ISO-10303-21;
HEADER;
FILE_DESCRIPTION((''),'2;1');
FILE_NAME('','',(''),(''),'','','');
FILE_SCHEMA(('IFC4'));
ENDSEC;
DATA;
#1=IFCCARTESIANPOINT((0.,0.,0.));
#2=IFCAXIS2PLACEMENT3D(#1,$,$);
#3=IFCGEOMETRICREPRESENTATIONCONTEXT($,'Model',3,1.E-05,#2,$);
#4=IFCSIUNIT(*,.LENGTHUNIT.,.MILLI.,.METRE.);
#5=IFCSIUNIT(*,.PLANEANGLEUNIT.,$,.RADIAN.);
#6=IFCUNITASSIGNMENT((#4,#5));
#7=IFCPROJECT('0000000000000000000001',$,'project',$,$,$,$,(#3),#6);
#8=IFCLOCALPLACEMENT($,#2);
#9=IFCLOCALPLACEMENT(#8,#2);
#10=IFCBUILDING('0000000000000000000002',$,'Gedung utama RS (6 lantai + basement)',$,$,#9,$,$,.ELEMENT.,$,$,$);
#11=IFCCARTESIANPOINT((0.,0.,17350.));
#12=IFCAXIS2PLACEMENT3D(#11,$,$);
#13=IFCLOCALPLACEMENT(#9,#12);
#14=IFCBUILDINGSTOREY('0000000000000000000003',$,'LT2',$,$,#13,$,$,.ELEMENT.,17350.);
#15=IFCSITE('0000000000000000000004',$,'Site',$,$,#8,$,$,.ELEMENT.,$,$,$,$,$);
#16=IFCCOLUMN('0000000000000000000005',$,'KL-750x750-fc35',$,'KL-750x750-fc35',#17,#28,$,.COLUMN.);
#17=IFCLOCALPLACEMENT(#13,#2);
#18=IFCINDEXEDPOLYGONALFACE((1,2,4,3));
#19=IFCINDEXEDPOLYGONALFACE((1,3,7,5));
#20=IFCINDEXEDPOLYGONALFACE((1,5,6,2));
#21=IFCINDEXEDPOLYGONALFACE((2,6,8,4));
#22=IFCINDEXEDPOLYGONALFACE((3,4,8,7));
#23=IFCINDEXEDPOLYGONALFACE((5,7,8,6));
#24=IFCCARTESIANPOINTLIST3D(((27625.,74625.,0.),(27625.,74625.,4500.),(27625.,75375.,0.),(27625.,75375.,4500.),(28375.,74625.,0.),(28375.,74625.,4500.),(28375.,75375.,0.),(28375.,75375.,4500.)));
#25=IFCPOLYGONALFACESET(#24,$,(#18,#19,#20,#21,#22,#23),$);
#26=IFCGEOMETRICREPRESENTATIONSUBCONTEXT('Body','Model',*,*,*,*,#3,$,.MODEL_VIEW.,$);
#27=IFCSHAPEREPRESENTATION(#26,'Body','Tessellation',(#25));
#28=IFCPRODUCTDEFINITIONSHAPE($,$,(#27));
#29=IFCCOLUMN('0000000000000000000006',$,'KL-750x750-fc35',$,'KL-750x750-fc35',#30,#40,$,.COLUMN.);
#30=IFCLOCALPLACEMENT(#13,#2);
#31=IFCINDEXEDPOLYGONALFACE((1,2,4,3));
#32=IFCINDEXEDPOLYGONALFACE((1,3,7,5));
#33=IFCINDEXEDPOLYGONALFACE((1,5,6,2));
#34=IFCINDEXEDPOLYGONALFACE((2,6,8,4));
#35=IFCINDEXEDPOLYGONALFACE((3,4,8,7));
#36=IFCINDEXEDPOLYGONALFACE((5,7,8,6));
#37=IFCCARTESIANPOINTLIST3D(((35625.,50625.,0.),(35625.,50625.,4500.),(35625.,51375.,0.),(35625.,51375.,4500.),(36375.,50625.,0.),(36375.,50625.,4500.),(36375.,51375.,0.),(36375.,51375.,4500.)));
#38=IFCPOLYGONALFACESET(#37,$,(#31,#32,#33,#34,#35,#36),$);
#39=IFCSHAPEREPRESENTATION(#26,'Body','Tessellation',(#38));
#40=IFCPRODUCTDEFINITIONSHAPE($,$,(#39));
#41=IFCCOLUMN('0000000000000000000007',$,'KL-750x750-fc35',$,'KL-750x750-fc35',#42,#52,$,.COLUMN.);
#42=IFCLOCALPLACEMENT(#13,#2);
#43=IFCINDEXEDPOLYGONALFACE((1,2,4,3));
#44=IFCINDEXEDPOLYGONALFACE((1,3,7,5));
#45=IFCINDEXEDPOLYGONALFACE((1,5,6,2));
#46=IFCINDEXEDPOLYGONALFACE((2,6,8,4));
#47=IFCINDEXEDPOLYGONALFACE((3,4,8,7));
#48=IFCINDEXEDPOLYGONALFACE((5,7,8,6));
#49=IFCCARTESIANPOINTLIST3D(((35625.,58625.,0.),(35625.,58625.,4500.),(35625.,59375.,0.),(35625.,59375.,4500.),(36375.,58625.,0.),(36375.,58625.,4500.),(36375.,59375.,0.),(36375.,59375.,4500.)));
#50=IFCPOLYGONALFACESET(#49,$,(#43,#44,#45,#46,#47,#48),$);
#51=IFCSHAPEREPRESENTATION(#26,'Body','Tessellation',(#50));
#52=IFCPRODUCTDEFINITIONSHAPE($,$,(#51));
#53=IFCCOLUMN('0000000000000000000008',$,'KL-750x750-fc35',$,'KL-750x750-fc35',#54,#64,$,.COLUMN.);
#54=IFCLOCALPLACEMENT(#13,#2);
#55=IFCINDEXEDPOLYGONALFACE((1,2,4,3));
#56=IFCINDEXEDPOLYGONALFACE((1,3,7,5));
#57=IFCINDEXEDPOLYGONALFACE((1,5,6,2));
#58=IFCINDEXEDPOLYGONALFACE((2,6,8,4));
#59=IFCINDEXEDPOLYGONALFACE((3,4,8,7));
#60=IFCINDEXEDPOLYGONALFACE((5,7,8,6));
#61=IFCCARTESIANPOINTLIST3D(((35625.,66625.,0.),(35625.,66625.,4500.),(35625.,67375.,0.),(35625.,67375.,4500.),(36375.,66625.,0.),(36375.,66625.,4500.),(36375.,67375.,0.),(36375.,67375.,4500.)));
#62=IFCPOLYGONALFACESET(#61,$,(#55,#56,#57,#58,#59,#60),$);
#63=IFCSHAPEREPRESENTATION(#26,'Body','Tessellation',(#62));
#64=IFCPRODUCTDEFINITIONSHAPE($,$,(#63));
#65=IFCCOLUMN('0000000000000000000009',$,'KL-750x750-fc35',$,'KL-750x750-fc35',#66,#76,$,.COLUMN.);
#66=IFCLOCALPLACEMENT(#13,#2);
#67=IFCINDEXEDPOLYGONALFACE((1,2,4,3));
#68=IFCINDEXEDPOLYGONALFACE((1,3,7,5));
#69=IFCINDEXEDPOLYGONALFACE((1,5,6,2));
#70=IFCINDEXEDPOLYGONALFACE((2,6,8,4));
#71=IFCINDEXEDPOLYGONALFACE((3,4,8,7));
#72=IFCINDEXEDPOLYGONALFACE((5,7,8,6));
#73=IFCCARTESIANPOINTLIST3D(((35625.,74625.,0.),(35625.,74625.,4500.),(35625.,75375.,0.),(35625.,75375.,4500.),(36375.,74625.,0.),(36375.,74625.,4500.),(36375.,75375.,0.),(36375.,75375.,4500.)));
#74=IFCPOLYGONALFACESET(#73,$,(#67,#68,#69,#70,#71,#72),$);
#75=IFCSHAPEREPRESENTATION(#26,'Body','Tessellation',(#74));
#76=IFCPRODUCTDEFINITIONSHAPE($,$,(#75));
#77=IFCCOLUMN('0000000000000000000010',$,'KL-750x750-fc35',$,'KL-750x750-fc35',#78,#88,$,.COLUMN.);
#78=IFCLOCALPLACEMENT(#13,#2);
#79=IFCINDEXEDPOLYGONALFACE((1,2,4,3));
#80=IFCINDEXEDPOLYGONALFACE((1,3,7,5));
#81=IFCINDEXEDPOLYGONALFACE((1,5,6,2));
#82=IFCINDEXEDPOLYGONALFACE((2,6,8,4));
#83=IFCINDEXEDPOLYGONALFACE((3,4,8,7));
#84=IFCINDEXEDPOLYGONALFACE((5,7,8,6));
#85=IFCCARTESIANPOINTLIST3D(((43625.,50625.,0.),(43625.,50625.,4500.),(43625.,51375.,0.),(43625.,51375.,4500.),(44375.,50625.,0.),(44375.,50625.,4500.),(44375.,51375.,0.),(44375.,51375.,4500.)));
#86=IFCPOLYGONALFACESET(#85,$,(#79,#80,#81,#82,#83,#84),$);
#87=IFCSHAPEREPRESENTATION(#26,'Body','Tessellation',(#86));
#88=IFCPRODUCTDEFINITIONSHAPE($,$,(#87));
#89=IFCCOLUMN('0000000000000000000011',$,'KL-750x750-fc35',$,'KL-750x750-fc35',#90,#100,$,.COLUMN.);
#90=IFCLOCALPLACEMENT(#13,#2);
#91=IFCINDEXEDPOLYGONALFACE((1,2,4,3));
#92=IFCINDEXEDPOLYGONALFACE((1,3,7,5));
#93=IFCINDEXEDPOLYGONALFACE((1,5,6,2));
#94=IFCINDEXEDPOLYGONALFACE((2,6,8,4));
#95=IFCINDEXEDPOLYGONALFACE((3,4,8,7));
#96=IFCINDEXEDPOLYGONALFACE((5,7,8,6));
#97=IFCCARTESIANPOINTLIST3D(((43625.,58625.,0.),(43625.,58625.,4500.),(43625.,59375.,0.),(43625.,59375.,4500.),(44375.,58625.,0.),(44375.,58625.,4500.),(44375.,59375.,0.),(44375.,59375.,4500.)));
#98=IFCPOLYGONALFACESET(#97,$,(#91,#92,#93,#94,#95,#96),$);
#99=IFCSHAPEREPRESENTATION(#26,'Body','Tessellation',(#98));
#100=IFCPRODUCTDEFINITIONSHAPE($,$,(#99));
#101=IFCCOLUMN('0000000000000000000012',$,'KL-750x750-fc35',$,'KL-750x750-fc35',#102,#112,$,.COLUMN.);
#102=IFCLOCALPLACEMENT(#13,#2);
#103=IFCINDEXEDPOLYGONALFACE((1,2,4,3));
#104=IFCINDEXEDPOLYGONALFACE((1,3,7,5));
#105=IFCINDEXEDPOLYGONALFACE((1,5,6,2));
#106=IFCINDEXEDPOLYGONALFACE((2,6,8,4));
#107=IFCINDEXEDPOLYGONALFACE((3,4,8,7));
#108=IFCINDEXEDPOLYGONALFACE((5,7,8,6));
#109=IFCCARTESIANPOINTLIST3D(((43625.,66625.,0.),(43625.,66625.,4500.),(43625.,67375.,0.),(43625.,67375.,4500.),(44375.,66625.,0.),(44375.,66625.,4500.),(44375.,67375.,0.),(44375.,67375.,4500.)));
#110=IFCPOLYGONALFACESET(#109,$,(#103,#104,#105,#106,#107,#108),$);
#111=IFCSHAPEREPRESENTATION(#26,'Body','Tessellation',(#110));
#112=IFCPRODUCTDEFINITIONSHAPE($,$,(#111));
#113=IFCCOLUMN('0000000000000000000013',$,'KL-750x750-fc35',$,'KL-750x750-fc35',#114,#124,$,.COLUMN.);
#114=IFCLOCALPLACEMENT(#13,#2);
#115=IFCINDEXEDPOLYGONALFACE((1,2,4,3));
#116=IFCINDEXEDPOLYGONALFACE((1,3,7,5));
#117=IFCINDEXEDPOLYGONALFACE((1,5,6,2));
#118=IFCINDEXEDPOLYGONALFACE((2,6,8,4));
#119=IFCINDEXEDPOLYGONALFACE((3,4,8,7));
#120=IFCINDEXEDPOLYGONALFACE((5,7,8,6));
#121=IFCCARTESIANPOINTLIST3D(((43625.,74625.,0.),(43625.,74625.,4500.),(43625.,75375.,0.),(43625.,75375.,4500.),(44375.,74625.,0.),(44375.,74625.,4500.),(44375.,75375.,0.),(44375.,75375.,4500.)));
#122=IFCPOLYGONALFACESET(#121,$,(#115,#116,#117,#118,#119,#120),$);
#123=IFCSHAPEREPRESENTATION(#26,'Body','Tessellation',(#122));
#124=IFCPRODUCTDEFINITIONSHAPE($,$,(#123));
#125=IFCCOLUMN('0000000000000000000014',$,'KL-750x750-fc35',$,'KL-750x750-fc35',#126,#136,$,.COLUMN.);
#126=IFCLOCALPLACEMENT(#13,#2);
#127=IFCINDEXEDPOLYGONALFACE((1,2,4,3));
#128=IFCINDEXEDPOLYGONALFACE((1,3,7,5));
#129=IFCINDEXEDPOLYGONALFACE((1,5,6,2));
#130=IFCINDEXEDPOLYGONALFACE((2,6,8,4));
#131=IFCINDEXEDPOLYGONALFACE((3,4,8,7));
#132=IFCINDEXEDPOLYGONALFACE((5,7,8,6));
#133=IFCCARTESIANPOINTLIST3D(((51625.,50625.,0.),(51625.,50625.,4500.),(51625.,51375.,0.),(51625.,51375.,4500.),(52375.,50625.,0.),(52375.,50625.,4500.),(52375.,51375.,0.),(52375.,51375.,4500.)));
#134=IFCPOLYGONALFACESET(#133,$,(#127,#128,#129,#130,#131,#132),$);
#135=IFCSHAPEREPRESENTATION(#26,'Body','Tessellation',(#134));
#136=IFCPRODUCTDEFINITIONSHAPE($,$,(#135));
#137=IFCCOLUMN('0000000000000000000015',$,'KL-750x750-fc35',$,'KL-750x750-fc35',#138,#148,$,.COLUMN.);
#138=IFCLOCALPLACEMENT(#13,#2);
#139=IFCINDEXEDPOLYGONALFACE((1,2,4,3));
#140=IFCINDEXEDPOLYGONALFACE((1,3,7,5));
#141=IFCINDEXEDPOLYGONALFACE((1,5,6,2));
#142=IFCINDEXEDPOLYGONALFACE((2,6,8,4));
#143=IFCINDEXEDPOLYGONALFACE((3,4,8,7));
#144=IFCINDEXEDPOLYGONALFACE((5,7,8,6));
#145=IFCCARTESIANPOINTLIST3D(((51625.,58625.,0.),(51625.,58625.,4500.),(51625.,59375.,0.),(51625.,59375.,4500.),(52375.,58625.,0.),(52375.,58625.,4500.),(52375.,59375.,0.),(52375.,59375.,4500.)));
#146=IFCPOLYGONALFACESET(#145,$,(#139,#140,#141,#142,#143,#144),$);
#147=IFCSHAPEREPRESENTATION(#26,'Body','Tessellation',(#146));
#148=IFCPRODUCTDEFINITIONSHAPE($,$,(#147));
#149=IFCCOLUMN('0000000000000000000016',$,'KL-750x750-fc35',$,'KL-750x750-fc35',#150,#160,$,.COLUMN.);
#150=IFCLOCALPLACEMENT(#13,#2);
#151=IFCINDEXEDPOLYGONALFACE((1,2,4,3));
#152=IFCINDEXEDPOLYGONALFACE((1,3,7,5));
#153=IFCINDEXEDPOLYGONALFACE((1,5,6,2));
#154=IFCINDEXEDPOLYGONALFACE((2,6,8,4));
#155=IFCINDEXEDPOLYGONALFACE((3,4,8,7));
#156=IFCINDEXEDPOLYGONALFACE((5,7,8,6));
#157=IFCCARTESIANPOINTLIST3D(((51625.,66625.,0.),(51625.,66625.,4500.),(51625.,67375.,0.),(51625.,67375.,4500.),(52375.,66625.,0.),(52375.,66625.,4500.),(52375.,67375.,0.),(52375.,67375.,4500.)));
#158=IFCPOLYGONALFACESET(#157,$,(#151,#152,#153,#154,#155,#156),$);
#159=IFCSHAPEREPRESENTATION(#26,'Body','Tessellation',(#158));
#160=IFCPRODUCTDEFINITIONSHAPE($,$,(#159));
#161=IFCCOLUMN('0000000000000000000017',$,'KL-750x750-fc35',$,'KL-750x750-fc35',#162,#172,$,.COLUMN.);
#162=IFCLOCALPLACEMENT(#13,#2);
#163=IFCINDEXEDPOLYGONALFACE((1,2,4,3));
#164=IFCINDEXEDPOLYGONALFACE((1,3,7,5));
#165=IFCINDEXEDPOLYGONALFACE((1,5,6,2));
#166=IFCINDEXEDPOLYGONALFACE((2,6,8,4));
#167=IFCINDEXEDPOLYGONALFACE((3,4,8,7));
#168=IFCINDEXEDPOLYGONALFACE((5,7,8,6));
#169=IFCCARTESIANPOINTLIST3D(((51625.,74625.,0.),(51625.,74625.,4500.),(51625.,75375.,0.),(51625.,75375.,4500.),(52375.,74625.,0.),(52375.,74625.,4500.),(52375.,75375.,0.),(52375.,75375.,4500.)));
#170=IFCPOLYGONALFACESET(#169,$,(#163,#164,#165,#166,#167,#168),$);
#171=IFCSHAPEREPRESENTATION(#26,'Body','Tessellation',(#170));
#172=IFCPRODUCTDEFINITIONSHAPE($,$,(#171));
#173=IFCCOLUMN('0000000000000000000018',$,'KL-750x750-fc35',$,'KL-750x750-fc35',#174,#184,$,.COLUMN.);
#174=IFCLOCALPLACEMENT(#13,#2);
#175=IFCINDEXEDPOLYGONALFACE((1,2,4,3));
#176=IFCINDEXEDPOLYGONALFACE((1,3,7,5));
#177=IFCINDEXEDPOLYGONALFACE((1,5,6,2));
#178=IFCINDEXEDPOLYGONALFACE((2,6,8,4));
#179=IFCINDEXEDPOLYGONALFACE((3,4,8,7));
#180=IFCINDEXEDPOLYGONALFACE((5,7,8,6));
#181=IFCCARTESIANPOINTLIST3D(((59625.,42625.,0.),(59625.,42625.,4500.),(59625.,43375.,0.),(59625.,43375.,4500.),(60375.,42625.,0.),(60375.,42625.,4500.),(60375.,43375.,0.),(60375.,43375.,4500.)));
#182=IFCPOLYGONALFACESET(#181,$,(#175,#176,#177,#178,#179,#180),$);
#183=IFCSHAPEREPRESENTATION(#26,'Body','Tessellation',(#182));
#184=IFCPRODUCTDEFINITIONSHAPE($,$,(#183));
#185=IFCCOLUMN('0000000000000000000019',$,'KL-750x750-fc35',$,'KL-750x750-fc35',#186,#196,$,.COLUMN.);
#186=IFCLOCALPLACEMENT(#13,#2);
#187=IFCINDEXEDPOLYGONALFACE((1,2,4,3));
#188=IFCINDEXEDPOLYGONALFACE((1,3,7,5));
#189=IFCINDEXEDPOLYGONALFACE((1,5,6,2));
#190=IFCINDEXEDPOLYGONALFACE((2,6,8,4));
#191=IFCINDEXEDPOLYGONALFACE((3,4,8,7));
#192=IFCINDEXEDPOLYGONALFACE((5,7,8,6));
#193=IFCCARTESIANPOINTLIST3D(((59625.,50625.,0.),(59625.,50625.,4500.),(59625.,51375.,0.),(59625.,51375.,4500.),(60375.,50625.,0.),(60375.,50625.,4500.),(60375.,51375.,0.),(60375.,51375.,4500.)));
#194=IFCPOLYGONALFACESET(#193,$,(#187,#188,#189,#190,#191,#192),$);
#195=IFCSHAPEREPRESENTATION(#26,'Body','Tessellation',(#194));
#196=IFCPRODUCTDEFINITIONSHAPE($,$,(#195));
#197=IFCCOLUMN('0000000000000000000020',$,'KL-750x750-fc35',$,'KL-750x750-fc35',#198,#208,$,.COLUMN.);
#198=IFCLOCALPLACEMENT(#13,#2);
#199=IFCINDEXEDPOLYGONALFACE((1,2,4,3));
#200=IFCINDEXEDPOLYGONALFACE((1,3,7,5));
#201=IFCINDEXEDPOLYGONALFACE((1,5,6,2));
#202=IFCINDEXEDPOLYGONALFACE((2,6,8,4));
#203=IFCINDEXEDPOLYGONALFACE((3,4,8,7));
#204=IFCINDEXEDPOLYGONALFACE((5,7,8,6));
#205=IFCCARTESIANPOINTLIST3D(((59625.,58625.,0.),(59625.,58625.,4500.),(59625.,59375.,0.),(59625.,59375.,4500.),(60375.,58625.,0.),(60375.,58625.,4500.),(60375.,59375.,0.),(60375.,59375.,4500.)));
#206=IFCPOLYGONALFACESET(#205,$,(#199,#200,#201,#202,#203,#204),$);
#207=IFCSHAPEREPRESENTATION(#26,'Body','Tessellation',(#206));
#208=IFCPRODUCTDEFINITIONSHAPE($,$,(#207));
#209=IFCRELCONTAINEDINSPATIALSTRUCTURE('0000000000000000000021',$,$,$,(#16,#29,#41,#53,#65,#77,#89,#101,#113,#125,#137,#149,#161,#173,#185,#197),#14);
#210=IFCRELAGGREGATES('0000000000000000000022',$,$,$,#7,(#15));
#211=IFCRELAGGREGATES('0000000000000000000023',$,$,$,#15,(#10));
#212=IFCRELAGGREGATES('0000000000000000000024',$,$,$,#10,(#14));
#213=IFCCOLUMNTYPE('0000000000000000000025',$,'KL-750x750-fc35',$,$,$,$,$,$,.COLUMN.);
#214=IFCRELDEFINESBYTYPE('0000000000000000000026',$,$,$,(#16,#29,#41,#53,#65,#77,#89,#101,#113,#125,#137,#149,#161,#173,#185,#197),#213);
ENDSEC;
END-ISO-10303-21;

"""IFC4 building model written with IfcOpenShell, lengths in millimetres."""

from ifc_helpers import new_model, si_unit, frame, origin, origin_2d, place, context, subcontext, project, spatial, rectangle, extrude, material_profile, profile_set, profile_usage, type_object, element, save


model = new_model("IFC4")

# Units and contexts
model_context = context("Model", 3, precision=1e-05, world=origin())
body_context = subcontext(model_context, "Body", "Model", "MODEL_VIEW")
ifc_project = project(units=[si_unit("LENGTHUNIT", "METRE", prefix="MILLI"), si_unit("PLANEANGLEUNIT", "RADIAN")], contexts=[model_context])

# Site, building, storey
site_placement = place(None, origin())
site = spatial("IfcSite", under=ifc_project, at=site_placement, Name="Site", CompositionType="ELEMENT")
building_placement = place(site_placement, origin())
building = spatial("IfcBuilding", under=site, at=building_placement, Name="Gedung utama RS (6 lantai + basement)", CompositionType="ELEMENT")
storey_placement = place(building_placement, frame((0.0, 0.0, 17350.0)))
storey = spatial("IfcBuildingStorey", under=building, at=storey_placement, Name="LT2", CompositionType="ELEMENT", Elevation=17350.0)

# Columns
ifc_material_profile = material_profile(None, rectangle(XDim=750.0, YDim=750.0, at=origin_2d()), Name="KL-750x750-fc35")
ifc_profile_set = profile_set([ifc_material_profile], Name="KL-750x750-fc35")
ifc_profile_usage = profile_usage(ifc_profile_set, cardinal=5)
column_type = type_object("IfcColumnType", Name="KL-750x750-fc35", PredefinedType="COLUMN", material=ifc_profile_set)
for number, where, z_axis, x_axis, name in (
    (1, (28000.0, 75000.0, 0.0), (0.0, 0.0, 1.0), (1.0, 0.0, 0.0), "KL-750x750-fc35"),
    (2, (36000.0, 51000.0, 0.0), (0.0, 0.0, 1.0), (1.0, 0.0, 0.0), "KL-750x750-fc35"),
    (3, (36000.0, 59000.0, 0.0), (0.0, 0.0, 1.0), (1.0, 0.0, 0.0), "KL-750x750-fc35"),
    (4, (36000.0, 67000.0, 0.0), (0.0, 0.0, 1.0), (1.0, 0.0, 0.0), "KL-750x750-fc35"),
    (5, (36000.0, 75000.0, 0.0), (0.0, 0.0, 1.0), (1.0, 0.0, 0.0), "KL-750x750-fc35"),
    (6, (44000.0, 51000.0, 0.0), (0.0, 0.0, 1.0), (1.0, 0.0, 0.0), "KL-750x750-fc35"),
    (7, (44000.0, 59000.0, 0.0), (0.0, 0.0, 1.0), (1.0, 0.0, 0.0), "KL-750x750-fc35"),
    (8, (44000.0, 67000.0, 0.0), (0.0, 0.0, 1.0), (1.0, 0.0, 0.0), "KL-750x750-fc35"),
    (9, (44000.0, 75000.0, 0.0), (0.0, 0.0, 1.0), (1.0, 0.0, 0.0), "KL-750x750-fc35"),
    (10, (52000.0, 51000.0, 0.0), (0.0, 0.0, 1.0), (1.0, 0.0, 0.0), "KL-750x750-fc35"),
    (11, (52000.0, 59000.0, 0.0), (0.0, 0.0, 1.0), (1.0, 0.0, 0.0), "KL-750x750-fc35"),
    (12, (52000.0, 67000.0, 0.0), (0.0, 0.0, 1.0), (1.0, 0.0, 0.0), "KL-750x750-fc35"),
    (13, (52000.0, 75000.0, 0.0), (0.0, 0.0, 1.0), (1.0, 0.0, 0.0), "KL-750x750-fc35"),
    (14, (60000.0, 43000.0, 0.0), (0.0, 0.0, 1.0), (1.0, 0.0, 0.0), "KL-750x750-fc35"),
    (15, (60000.0, 51000.0, 0.0), (0.0, 0.0, 1.0), (1.0, 0.0, 0.0), "KL-750x750-fc35"),
    (16, (60000.0, 59000.0, 0.0), (0.0, 0.0, 1.0), (1.0, 0.0, 0.0), "KL-750x750-fc35"),
):
    element("IfcColumn", number, at=place(storey_placement, frame(where, z_axis=z_axis, x_axis=x_axis)), inside=storey, type_object=column_type, material=ifc_profile_usage, Name=name, ObjectType="KL-750x750-fc35", PredefinedType="COLUMN", context=body_context, shape_type="SweptSolid", body=[
        extrude(rectangle(XDim=750.0, YDim=750.0, at=origin_2d()), origin(), (0.0, 0.0, 1.0), 4500.0),
    ])

save(model, "model.ifc")
